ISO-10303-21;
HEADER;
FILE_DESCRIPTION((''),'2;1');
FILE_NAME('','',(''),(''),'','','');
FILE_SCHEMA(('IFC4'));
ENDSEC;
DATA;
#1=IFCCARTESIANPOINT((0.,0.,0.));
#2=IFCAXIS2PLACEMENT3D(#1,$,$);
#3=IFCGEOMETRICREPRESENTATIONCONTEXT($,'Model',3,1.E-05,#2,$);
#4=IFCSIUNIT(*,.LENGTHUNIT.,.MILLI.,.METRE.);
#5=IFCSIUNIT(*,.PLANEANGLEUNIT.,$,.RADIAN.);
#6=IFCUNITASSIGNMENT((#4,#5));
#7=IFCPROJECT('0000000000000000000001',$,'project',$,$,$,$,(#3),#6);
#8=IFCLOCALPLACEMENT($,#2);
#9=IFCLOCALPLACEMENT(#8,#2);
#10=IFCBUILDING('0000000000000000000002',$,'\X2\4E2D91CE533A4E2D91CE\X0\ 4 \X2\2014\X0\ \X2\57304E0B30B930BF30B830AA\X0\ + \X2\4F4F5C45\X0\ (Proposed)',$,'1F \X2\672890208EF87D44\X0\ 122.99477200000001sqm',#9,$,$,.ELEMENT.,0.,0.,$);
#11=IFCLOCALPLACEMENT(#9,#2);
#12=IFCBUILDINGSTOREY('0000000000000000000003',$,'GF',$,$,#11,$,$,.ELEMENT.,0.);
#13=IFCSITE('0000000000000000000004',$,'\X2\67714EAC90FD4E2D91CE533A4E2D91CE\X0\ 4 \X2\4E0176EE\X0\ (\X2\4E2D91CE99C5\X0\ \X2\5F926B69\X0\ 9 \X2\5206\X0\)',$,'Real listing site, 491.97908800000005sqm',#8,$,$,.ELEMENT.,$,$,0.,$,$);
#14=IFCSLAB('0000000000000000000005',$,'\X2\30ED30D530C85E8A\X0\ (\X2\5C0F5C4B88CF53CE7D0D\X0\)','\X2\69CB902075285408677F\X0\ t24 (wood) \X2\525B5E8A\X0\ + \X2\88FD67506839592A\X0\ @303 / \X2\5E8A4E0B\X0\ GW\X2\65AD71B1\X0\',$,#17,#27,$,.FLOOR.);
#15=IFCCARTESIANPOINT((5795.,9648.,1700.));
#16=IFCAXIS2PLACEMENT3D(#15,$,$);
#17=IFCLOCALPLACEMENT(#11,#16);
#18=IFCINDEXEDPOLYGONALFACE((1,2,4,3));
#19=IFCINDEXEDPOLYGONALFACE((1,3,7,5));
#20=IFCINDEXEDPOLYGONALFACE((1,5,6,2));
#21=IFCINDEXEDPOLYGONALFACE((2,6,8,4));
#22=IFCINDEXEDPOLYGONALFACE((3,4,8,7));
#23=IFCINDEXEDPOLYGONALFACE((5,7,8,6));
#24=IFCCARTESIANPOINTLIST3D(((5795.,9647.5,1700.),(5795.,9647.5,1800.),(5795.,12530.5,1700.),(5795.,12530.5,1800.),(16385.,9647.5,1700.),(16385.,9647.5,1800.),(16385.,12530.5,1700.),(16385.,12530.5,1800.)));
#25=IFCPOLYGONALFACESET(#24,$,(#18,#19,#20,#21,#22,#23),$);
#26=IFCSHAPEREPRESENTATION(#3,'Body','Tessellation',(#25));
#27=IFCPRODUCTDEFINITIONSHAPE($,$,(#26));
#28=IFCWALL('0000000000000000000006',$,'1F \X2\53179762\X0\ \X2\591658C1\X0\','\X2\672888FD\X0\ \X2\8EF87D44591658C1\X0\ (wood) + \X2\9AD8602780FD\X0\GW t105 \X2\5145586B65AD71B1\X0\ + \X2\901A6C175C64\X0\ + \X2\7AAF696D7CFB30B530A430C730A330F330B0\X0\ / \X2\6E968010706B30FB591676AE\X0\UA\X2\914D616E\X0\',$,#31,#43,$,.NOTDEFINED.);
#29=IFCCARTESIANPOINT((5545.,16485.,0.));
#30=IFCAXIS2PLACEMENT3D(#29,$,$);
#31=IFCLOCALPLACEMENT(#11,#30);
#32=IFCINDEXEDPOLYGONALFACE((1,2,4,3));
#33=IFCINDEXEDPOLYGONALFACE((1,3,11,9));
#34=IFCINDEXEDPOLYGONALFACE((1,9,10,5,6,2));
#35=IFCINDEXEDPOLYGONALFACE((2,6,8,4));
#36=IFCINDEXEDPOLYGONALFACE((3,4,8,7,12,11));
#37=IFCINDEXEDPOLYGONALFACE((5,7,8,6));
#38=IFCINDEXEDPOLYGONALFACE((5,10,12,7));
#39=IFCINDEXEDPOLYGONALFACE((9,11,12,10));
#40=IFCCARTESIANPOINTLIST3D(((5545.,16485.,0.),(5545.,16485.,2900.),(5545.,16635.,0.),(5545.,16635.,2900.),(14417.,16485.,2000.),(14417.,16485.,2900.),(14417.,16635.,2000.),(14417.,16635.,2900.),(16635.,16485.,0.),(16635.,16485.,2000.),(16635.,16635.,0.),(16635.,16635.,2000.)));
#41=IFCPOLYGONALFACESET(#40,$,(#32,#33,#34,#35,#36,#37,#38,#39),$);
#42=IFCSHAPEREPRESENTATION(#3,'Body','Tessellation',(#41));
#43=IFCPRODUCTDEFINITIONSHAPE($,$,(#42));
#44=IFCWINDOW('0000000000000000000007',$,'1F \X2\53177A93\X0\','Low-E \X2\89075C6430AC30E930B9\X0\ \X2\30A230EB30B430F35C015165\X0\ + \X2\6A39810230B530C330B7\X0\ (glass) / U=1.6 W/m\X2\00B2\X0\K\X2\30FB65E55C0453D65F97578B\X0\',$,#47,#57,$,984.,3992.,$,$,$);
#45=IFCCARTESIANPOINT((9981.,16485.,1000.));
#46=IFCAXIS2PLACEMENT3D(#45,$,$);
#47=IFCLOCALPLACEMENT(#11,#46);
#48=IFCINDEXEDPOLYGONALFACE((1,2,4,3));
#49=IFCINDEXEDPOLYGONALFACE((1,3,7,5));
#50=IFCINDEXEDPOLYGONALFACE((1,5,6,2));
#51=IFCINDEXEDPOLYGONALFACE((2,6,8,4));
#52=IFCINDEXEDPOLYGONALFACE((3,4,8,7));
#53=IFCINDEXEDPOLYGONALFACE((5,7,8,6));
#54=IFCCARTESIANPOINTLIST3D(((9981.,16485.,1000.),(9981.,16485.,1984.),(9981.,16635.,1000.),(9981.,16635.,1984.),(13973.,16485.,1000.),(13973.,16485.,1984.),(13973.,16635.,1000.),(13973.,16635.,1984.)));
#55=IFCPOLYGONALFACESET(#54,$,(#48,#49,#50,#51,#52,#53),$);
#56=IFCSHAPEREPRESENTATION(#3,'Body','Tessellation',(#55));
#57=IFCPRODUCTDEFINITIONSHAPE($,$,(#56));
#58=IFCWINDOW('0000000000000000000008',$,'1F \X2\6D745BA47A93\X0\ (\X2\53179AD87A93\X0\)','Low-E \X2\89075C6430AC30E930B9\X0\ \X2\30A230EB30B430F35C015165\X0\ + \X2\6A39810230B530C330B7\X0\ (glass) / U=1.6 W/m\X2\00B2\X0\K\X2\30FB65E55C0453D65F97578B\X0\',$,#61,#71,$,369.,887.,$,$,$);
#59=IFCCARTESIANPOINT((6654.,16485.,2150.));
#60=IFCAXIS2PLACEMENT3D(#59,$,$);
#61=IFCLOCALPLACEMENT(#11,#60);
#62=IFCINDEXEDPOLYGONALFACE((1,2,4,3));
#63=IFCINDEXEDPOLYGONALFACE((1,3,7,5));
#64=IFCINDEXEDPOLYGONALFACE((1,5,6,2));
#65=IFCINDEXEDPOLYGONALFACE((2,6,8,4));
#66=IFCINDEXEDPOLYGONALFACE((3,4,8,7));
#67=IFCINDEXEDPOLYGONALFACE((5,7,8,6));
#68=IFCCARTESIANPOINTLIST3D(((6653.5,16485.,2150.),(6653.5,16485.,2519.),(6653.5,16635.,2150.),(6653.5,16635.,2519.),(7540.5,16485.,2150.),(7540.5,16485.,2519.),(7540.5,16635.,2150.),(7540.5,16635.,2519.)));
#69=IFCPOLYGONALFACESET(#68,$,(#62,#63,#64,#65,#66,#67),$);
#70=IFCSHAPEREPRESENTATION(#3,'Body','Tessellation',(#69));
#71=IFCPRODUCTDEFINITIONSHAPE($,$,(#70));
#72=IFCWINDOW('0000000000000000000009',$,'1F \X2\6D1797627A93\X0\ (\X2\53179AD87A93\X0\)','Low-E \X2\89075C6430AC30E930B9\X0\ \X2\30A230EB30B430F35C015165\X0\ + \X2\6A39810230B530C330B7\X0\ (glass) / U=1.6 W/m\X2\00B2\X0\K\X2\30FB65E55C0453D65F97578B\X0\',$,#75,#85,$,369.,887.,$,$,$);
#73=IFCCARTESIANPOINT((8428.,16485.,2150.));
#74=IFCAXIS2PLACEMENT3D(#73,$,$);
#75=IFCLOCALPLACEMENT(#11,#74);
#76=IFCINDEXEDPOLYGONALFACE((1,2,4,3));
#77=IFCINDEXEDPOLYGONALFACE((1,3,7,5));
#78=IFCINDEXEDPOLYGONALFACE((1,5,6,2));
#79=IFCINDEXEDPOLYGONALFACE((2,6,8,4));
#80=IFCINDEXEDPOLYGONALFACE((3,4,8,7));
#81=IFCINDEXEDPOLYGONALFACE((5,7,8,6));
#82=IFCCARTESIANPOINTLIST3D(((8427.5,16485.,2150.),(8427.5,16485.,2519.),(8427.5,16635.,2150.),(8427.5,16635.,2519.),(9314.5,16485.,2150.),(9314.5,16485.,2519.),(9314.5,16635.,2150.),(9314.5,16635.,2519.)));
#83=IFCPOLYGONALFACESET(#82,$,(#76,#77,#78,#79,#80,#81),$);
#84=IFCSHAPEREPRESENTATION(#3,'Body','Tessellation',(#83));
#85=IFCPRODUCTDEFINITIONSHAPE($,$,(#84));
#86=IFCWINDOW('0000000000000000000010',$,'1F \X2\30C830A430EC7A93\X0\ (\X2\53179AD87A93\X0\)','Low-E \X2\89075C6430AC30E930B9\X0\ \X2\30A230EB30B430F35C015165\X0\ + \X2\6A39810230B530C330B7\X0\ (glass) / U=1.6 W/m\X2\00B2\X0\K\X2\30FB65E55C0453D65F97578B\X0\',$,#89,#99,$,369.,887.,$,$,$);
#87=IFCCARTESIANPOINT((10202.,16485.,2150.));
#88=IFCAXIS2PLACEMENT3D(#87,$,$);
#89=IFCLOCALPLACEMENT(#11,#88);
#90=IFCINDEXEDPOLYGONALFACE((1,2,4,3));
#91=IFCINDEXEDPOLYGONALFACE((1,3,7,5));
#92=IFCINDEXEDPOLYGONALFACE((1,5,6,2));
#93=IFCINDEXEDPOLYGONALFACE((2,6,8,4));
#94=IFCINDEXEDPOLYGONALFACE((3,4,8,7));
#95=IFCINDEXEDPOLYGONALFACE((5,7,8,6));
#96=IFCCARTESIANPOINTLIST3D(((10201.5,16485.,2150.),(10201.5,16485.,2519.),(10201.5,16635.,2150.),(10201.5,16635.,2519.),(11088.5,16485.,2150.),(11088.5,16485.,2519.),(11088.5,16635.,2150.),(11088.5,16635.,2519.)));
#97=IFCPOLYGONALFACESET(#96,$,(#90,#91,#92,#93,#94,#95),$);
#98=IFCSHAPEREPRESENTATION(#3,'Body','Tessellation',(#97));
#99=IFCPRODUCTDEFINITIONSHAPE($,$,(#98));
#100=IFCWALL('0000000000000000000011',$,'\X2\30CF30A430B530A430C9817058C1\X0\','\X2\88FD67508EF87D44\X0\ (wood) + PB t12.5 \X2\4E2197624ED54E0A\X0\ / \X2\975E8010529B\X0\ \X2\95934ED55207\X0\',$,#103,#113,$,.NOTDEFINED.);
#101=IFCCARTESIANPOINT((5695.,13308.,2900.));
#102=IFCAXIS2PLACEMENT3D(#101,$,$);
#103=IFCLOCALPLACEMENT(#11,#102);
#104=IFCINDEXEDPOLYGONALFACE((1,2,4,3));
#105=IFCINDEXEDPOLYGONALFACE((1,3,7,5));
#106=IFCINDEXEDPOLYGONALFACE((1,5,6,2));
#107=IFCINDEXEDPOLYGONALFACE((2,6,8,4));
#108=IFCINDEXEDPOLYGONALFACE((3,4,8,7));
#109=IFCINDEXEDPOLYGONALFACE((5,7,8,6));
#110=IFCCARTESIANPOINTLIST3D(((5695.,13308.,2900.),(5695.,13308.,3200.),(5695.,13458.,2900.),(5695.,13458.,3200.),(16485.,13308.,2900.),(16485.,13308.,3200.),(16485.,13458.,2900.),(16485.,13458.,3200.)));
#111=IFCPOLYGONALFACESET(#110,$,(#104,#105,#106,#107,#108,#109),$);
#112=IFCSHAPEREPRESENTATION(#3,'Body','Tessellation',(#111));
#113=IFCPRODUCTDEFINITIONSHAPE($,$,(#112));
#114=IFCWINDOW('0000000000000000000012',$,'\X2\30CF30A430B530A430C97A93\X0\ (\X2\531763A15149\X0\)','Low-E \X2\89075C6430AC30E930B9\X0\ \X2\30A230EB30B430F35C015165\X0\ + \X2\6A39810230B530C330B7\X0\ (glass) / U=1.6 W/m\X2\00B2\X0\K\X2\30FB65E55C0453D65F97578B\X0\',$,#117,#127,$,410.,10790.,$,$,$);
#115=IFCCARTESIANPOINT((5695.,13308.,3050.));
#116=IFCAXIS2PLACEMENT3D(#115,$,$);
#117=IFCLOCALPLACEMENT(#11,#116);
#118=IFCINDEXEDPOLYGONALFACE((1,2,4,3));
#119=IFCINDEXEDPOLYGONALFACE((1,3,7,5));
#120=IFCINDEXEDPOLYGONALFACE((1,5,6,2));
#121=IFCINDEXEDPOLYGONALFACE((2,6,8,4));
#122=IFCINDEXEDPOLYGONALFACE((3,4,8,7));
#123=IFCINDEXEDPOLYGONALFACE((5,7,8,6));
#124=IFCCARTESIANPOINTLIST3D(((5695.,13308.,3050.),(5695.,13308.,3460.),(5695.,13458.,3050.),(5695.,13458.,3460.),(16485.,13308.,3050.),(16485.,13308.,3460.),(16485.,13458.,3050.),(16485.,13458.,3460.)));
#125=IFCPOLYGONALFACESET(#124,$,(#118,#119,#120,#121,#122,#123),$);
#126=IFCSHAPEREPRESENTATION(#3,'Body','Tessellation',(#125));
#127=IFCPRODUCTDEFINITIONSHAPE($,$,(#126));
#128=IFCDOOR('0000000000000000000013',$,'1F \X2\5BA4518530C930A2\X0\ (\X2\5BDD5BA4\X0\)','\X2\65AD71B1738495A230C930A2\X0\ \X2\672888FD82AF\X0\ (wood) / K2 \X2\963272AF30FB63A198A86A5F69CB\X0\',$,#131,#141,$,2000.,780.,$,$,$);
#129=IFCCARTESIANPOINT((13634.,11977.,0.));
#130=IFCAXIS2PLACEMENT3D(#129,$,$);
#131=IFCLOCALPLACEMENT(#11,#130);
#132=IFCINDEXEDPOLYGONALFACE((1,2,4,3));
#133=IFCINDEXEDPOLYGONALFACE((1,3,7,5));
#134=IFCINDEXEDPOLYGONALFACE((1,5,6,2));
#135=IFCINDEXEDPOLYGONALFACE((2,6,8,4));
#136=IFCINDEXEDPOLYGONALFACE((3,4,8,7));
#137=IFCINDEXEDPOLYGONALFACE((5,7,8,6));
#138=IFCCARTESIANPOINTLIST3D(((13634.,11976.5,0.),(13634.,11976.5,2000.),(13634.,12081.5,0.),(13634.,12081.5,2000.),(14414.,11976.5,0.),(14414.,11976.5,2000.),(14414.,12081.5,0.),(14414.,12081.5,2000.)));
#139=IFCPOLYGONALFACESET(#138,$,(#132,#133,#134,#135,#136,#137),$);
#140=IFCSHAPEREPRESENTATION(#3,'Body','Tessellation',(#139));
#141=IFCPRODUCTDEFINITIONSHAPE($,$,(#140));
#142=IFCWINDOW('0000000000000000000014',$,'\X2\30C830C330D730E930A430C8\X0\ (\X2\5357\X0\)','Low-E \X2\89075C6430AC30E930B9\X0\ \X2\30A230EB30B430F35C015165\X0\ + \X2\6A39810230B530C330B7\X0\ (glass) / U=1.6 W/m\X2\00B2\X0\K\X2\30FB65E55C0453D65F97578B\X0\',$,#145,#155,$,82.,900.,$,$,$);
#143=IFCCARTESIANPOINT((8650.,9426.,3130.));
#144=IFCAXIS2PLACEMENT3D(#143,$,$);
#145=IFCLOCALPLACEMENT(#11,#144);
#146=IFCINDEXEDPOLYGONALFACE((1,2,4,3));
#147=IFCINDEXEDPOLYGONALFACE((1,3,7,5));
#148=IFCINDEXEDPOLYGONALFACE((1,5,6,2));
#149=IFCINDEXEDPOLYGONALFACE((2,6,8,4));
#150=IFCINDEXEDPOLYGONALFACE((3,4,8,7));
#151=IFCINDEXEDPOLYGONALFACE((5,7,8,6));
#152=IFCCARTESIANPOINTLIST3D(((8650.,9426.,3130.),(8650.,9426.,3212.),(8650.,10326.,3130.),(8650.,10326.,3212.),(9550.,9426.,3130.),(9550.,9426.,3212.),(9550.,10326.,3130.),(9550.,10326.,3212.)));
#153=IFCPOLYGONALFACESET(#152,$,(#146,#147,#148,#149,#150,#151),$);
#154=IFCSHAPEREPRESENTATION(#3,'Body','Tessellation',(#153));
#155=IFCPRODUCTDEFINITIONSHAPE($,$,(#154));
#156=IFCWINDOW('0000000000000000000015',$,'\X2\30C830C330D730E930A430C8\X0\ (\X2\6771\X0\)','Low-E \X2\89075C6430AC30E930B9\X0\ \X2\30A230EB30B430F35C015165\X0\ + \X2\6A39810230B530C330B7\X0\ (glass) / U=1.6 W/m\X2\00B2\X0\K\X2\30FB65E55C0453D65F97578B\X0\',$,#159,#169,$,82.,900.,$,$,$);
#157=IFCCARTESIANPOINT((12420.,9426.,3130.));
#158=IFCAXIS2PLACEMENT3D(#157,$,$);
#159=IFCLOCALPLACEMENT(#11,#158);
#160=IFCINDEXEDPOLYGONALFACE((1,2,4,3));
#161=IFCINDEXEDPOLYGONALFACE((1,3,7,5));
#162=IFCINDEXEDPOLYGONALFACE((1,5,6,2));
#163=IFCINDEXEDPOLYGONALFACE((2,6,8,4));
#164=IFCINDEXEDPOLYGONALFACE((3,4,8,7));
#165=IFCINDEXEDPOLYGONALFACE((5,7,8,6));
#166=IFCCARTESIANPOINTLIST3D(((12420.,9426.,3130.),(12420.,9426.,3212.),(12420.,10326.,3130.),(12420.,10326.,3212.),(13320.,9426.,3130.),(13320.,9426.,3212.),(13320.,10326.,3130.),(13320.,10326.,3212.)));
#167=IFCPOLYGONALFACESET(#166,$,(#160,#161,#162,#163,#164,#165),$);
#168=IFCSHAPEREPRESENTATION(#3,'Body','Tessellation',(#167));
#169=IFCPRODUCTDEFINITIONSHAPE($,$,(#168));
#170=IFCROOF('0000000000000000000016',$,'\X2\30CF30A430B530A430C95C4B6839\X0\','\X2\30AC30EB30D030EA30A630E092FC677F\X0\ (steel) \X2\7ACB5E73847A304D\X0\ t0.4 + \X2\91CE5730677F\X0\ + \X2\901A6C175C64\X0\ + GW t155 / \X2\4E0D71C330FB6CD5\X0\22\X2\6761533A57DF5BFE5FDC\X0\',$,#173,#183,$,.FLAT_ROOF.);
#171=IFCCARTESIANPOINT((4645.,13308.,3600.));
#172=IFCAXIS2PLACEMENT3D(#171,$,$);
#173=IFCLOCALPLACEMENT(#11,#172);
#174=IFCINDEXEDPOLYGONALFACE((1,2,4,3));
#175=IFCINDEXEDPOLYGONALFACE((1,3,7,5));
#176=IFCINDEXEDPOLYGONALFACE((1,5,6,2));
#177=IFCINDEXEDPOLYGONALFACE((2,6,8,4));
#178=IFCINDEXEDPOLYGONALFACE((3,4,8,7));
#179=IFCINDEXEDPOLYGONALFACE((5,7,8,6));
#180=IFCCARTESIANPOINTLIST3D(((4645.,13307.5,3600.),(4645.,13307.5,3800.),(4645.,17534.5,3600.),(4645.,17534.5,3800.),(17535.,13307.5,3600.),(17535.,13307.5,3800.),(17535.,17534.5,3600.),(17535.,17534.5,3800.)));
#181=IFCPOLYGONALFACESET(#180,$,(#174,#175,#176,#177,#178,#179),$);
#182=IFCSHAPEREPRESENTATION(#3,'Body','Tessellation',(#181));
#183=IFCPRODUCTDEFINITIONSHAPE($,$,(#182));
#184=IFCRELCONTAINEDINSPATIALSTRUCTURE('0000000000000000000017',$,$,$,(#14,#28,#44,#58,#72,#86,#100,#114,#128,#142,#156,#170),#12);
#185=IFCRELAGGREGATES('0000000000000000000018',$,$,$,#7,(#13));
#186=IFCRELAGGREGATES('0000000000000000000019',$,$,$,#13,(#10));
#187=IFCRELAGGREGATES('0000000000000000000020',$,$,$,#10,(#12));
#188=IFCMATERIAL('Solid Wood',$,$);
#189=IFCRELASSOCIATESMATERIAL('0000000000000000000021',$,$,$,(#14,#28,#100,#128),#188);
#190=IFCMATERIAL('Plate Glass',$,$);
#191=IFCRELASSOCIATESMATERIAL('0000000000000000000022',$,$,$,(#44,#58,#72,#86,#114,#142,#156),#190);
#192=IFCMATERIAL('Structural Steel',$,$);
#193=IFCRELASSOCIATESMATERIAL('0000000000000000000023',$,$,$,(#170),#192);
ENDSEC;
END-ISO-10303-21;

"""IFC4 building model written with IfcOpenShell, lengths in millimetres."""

from ifc_helpers import new_model, si_unit, frame, frame_2d, origin, place, context, project, spatial, rectangle, extrude, material, element, fill, save


model = new_model("IFC4")

# Units and contexts
model_context = context("Model", 3, precision=1e-05, world=origin())
ifc_project = project(units=[si_unit("LENGTHUNIT", "METRE", prefix="MILLI"), si_unit("PLANEANGLEUNIT", "RADIAN")], contexts=[model_context])

# Site, building, storey
site_placement = place(None, origin())
site = spatial("IfcSite", under=ifc_project, at=site_placement, Name="東京都中野区中野 4 丁目 (中野駅 徒歩 9 分)", ObjectType="Real listing site, 491.97908800000005sqm", CompositionType="ELEMENT", RefElevation=0.0)
building_placement = place(site_placement, origin())
building = spatial("IfcBuilding", under=site, at=building_placement, Name="中野区中野 4 — 地下スタジオ + 住居 (Proposed)", ObjectType="1F 木造軸組 122.99477200000001sqm", CompositionType="ELEMENT", ElevationOfRefHeight=0.0, ElevationOfTerrain=0.0)
storey_placement = place(building_placement, origin())
storey = spatial("IfcBuildingStorey", under=building, at=storey_placement, Name="GF", CompositionType="ELEMENT", Elevation=0.0)

# Slab
ifc_material_1 = material(Name="Solid Wood")
slab_placement = place(storey_placement, frame((5795.0, 9648.0, 1700.0)))
element("IfcSlab", 1, at=slab_placement, inside=storey, material=ifc_material_1, Name="ロフト床 (小屋裏収納)", Description="構造用合板 t24 (wood) 剛床 + 製材根太 @303 / 床下 GW断熱", PredefinedType="FLOOR", context=model_context, shape_type="SweptSolid", body=[
    extrude(rectangle(XDim=10590.0, YDim=2883.0, at=frame_2d((5295.0, 1441.0))), frame((5795.0, 9648.0, 1700.0)), (0.0, 0.0, 1.0), 100.0),
])

# Wall, openings, windows
wall_1_placement = place(storey_placement, frame((5545.0, 16485.0, 0.0)))
wall_1 = element("IfcWall", 2, at=wall_1_placement, inside=storey, material=ifc_material_1, Name="1F 北面 外壁", Description="木製 軸組外壁 (wood) + 高性能GW t105 充填断熱 + 通気層 + 窯業系サイディング / 準耐火・外皮UA配慮", PredefinedType="NOTDEFINED", context=model_context, shape_type="SweptSolid", body=[
    extrude(rectangle(XDim=11090.0, YDim=150.0, at=frame_2d((5545.0, 75.0))), frame((5545.0, 16485.0, 0.0)), (0.0, 0.0, 1.0), 2900.0),
])
opening_1_placement = place(storey_placement, frame((9981.0, 16485.0, 1000.0)))
opening_1 = element("IfcOpeningElement", 3, at=opening_1_placement, cuts=wall_1, PredefinedType="NOTDEFINED", context=model_context, shape_type="SweptSolid", body=[
    extrude(rectangle(XDim=3992.0, YDim=150.0, at=frame_2d((1996.0, 75.0))), frame((9981.0, 16485.0, 1000.0)), (0.0, 0.0, 1.0), 984.0),
])
opening_2_placement = place(storey_placement, frame((6654.0, 16485.0, 2150.0)))
opening_2 = element("IfcOpeningElement", 4, at=opening_2_placement, cuts=wall_1, PredefinedType="NOTDEFINED", context=model_context, shape_type="SweptSolid", body=[
    extrude(rectangle(XDim=887.0, YDim=150.0, at=frame_2d((443.0, 75.0))), frame((6654.0, 16485.0, 2150.0)), (0.0, 0.0, 1.0), 369.0),
])
opening_3_placement = place(storey_placement, frame((8428.0, 16485.0, 2150.0)))
opening_3 = element("IfcOpeningElement", 5, at=opening_3_placement, cuts=wall_1, PredefinedType="NOTDEFINED", context=model_context, shape_type="SweptSolid", body=[
    extrude(rectangle(XDim=887.0, YDim=150.0, at=frame_2d((443.0, 75.0))), frame((8428.0, 16485.0, 2150.0)), (0.0, 0.0, 1.0), 369.0),
])
opening_4_placement = place(storey_placement, frame((10202.0, 16485.0, 2150.0)))
opening_4 = element("IfcOpeningElement", 6, at=opening_4_placement, cuts=wall_1, PredefinedType="NOTDEFINED", context=model_context, shape_type="SweptSolid", body=[
    extrude(rectangle(XDim=887.0, YDim=150.0, at=frame_2d((443.0, 75.0))), frame((10202.0, 16485.0, 2150.0)), (0.0, 0.0, 1.0), 369.0),
])
ifc_material_2 = material(Name="Plate Glass")
window_1_placement = place(storey_placement, frame((9981.0, 16485.0, 1000.0)))
window_1 = element("IfcWindow", 7, at=window_1_placement, inside=storey, material=ifc_material_2, Name="1F 北窓", Description="Low-E 複層ガラス アルゴン封入 + 樹脂サッシ (glass) / U=1.6 W/m²K・日射取得型", OverallHeight=984.0, OverallWidth=3992.0, context=model_context, shape_type="SweptSolid", body=[
    extrude(rectangle(XDim=3992.0, YDim=150.0, at=frame_2d((1996.0, 75.0))), frame((9981.0, 16485.0, 1000.0)), (0.0, 0.0, 1.0), 984.0),
])
fill(opening_1, window_1)
window_2_placement = place(storey_placement, frame((6654.0, 16485.0, 2150.0)))
window_2 = element("IfcWindow", 8, at=window_2_placement, inside=storey, material=ifc_material_2, Name="1F 浴室窓 (北高窓)", Description="Low-E 複層ガラス アルゴン封入 + 樹脂サッシ (glass) / U=1.6 W/m²K・日射取得型", OverallHeight=369.0, OverallWidth=887.0, context=model_context, shape_type="SweptSolid", body=[
    extrude(rectangle(XDim=887.0, YDim=150.0, at=frame_2d((443.0, 75.0))), frame((6654.0, 16485.0, 2150.0)), (0.0, 0.0, 1.0), 369.0),
])
fill(opening_2, window_2)
window_3_placement = place(storey_placement, frame((8428.0, 16485.0, 2150.0)))
window_3 = element("IfcWindow", 9, at=window_3_placement, inside=storey, material=ifc_material_2, Name="1F 洗面窓 (北高窓)", Description="Low-E 複層ガラス アルゴン封入 + 樹脂サッシ (glass) / U=1.6 W/m²K・日射取得型", OverallHeight=369.0, OverallWidth=887.0, context=model_context, shape_type="SweptSolid", body=[
    extrude(rectangle(XDim=887.0, YDim=150.0, at=frame_2d((443.0, 75.0))), frame((8428.0, 16485.0, 2150.0)), (0.0, 0.0, 1.0), 369.0),
])
fill(opening_3, window_3)
window_4_placement = place(storey_placement, frame((10202.0, 16485.0, 2150.0)))
window_4 = element("IfcWindow", 10, at=window_4_placement, inside=storey, material=ifc_material_2, Name="1F トイレ窓 (北高窓)", Description="Low-E 複層ガラス アルゴン封入 + 樹脂サッシ (glass) / U=1.6 W/m²K・日射取得型", OverallHeight=369.0, OverallWidth=887.0, context=model_context, shape_type="SweptSolid", body=[
    extrude(rectangle(XDim=887.0, YDim=150.0, at=frame_2d((443.0, 75.0))), frame((10202.0, 16485.0, 2150.0)), (0.0, 0.0, 1.0), 369.0),
])
fill(opening_4, window_4)

# Wall, opening, window
wall_2_placement = place(storey_placement, frame((5695.0, 13308.0, 2900.0)))
wall_2 = element("IfcWall", 11, at=wall_2_placement, inside=storey, material=ifc_material_1, Name="ハイサイド腰壁", Description="製材軸組 (wood) + PB t12.5 両面仕上 / 非耐力 間仕切", PredefinedType="NOTDEFINED", context=model_context, shape_type="SweptSolid", body=[
    extrude(rectangle(XDim=10790.0, YDim=150.0, at=frame_2d((5395.0, 75.0))), frame((5695.0, 13308.0, 2900.0)), (0.0, 0.0, 1.0), 700.0),
])
opening_5_placement = place(storey_placement, frame((5695.0, 13308.0, 3050.0)))
opening_5 = element("IfcOpeningElement", 12, at=opening_5_placement, cuts=wall_2, PredefinedType="NOTDEFINED", context=model_context, shape_type="SweptSolid", body=[
    extrude(rectangle(XDim=10790.0, YDim=150.0, at=frame_2d((5395.0, 75.0))), frame((5695.0, 13308.0, 3050.0)), (0.0, 0.0, 1.0), 410.0),
])
window_5_placement = place(storey_placement, frame((5695.0, 13308.0, 3050.0)))
window_5 = element("IfcWindow", 13, at=window_5_placement, inside=storey, material=ifc_material_2, Name="ハイサイド窓 (北採光)", Description="Low-E 複層ガラス アルゴン封入 + 樹脂サッシ (glass) / U=1.6 W/m²K・日射取得型", OverallHeight=410.0, OverallWidth=10790.0, context=model_context, shape_type="SweptSolid", body=[
    extrude(rectangle(XDim=10790.0, YDim=150.0, at=frame_2d((5395.0, 75.0))), frame((5695.0, 13308.0, 3050.0)), (0.0, 0.0, 1.0), 410.0),
])
fill(opening_5, window_5)

# Door
door_1_placement = place(storey_placement, frame((13634.0, 11977.0, 0.0)))
element("IfcDoor", 14, at=door_1_placement, inside=storey, material=ifc_material_1, Name="1F 室内ドア (寝室)", Description="断熱玄関ドア 木製芯 (wood) / K2 防犯・採風機構", OverallHeight=2000.0, OverallWidth=780.0, context=model_context, shape_type="SweptSolid", body=[
    extrude(rectangle(XDim=780.0, YDim=105.0, at=frame_2d((390.0, 52.0))), frame((13634.0, 11977.0, 0.0)), (0.0, 0.0, 1.0), 2000.0),
])

# Windows
window_6_placement = place(storey_placement, frame((8650.0, 9426.0, 3130.0)))
element("IfcWindow", 15, at=window_6_placement, inside=storey, material=ifc_material_2, Name="トップライト (南)", Description="Low-E 複層ガラス アルゴン封入 + 樹脂サッシ (glass) / U=1.6 W/m²K・日射取得型", OverallHeight=82.0, OverallWidth=900.0, context=model_context, shape_type="SweptSolid", body=[
    extrude(rectangle(XDim=900.0, YDim=900.0, at=frame_2d((450.0, 450.0))), frame((8650.0, 9426.0, 3130.0)), (0.0, 0.0, 1.0), 82.0),
])
window_7_placement = place(storey_placement, frame((12420.0, 9426.0, 3130.0)))
element("IfcWindow", 16, at=window_7_placement, inside=storey, material=ifc_material_2, Name="トップライト (東)", Description="Low-E 複層ガラス アルゴン封入 + 樹脂サッシ (glass) / U=1.6 W/m²K・日射取得型", OverallHeight=82.0, OverallWidth=900.0, context=model_context, shape_type="SweptSolid", body=[
    extrude(rectangle(XDim=900.0, YDim=900.0, at=frame_2d((450.0, 450.0))), frame((12420.0, 9426.0, 3130.0)), (0.0, 0.0, 1.0), 82.0),
])

# Roof
ifc_material_3 = material(Name="Structural Steel")
roof_placement = place(storey_placement, frame((4645.0, 13308.0, 3600.0)))
element("IfcRoof", 17, at=roof_placement, inside=storey, material=ifc_material_3, Name="ハイサイド屋根", Description="ガルバリウム鋼板 (steel) 立平葺き t0.4 + 野地板 + 通気層 + GW t155 / 不燃・法22条区域対応", PredefinedType="FLAT_ROOF", context=model_context, shape_type="SweptSolid", body=[
    extrude(rectangle(XDim=12890.0, YDim=4227.0, at=frame_2d((6445.0, 2113.0))), frame((4645.0, 13308.0, 3600.0)), (0.0, 0.0, 1.0), 200.0),
])

save(model, "model.ifc")
